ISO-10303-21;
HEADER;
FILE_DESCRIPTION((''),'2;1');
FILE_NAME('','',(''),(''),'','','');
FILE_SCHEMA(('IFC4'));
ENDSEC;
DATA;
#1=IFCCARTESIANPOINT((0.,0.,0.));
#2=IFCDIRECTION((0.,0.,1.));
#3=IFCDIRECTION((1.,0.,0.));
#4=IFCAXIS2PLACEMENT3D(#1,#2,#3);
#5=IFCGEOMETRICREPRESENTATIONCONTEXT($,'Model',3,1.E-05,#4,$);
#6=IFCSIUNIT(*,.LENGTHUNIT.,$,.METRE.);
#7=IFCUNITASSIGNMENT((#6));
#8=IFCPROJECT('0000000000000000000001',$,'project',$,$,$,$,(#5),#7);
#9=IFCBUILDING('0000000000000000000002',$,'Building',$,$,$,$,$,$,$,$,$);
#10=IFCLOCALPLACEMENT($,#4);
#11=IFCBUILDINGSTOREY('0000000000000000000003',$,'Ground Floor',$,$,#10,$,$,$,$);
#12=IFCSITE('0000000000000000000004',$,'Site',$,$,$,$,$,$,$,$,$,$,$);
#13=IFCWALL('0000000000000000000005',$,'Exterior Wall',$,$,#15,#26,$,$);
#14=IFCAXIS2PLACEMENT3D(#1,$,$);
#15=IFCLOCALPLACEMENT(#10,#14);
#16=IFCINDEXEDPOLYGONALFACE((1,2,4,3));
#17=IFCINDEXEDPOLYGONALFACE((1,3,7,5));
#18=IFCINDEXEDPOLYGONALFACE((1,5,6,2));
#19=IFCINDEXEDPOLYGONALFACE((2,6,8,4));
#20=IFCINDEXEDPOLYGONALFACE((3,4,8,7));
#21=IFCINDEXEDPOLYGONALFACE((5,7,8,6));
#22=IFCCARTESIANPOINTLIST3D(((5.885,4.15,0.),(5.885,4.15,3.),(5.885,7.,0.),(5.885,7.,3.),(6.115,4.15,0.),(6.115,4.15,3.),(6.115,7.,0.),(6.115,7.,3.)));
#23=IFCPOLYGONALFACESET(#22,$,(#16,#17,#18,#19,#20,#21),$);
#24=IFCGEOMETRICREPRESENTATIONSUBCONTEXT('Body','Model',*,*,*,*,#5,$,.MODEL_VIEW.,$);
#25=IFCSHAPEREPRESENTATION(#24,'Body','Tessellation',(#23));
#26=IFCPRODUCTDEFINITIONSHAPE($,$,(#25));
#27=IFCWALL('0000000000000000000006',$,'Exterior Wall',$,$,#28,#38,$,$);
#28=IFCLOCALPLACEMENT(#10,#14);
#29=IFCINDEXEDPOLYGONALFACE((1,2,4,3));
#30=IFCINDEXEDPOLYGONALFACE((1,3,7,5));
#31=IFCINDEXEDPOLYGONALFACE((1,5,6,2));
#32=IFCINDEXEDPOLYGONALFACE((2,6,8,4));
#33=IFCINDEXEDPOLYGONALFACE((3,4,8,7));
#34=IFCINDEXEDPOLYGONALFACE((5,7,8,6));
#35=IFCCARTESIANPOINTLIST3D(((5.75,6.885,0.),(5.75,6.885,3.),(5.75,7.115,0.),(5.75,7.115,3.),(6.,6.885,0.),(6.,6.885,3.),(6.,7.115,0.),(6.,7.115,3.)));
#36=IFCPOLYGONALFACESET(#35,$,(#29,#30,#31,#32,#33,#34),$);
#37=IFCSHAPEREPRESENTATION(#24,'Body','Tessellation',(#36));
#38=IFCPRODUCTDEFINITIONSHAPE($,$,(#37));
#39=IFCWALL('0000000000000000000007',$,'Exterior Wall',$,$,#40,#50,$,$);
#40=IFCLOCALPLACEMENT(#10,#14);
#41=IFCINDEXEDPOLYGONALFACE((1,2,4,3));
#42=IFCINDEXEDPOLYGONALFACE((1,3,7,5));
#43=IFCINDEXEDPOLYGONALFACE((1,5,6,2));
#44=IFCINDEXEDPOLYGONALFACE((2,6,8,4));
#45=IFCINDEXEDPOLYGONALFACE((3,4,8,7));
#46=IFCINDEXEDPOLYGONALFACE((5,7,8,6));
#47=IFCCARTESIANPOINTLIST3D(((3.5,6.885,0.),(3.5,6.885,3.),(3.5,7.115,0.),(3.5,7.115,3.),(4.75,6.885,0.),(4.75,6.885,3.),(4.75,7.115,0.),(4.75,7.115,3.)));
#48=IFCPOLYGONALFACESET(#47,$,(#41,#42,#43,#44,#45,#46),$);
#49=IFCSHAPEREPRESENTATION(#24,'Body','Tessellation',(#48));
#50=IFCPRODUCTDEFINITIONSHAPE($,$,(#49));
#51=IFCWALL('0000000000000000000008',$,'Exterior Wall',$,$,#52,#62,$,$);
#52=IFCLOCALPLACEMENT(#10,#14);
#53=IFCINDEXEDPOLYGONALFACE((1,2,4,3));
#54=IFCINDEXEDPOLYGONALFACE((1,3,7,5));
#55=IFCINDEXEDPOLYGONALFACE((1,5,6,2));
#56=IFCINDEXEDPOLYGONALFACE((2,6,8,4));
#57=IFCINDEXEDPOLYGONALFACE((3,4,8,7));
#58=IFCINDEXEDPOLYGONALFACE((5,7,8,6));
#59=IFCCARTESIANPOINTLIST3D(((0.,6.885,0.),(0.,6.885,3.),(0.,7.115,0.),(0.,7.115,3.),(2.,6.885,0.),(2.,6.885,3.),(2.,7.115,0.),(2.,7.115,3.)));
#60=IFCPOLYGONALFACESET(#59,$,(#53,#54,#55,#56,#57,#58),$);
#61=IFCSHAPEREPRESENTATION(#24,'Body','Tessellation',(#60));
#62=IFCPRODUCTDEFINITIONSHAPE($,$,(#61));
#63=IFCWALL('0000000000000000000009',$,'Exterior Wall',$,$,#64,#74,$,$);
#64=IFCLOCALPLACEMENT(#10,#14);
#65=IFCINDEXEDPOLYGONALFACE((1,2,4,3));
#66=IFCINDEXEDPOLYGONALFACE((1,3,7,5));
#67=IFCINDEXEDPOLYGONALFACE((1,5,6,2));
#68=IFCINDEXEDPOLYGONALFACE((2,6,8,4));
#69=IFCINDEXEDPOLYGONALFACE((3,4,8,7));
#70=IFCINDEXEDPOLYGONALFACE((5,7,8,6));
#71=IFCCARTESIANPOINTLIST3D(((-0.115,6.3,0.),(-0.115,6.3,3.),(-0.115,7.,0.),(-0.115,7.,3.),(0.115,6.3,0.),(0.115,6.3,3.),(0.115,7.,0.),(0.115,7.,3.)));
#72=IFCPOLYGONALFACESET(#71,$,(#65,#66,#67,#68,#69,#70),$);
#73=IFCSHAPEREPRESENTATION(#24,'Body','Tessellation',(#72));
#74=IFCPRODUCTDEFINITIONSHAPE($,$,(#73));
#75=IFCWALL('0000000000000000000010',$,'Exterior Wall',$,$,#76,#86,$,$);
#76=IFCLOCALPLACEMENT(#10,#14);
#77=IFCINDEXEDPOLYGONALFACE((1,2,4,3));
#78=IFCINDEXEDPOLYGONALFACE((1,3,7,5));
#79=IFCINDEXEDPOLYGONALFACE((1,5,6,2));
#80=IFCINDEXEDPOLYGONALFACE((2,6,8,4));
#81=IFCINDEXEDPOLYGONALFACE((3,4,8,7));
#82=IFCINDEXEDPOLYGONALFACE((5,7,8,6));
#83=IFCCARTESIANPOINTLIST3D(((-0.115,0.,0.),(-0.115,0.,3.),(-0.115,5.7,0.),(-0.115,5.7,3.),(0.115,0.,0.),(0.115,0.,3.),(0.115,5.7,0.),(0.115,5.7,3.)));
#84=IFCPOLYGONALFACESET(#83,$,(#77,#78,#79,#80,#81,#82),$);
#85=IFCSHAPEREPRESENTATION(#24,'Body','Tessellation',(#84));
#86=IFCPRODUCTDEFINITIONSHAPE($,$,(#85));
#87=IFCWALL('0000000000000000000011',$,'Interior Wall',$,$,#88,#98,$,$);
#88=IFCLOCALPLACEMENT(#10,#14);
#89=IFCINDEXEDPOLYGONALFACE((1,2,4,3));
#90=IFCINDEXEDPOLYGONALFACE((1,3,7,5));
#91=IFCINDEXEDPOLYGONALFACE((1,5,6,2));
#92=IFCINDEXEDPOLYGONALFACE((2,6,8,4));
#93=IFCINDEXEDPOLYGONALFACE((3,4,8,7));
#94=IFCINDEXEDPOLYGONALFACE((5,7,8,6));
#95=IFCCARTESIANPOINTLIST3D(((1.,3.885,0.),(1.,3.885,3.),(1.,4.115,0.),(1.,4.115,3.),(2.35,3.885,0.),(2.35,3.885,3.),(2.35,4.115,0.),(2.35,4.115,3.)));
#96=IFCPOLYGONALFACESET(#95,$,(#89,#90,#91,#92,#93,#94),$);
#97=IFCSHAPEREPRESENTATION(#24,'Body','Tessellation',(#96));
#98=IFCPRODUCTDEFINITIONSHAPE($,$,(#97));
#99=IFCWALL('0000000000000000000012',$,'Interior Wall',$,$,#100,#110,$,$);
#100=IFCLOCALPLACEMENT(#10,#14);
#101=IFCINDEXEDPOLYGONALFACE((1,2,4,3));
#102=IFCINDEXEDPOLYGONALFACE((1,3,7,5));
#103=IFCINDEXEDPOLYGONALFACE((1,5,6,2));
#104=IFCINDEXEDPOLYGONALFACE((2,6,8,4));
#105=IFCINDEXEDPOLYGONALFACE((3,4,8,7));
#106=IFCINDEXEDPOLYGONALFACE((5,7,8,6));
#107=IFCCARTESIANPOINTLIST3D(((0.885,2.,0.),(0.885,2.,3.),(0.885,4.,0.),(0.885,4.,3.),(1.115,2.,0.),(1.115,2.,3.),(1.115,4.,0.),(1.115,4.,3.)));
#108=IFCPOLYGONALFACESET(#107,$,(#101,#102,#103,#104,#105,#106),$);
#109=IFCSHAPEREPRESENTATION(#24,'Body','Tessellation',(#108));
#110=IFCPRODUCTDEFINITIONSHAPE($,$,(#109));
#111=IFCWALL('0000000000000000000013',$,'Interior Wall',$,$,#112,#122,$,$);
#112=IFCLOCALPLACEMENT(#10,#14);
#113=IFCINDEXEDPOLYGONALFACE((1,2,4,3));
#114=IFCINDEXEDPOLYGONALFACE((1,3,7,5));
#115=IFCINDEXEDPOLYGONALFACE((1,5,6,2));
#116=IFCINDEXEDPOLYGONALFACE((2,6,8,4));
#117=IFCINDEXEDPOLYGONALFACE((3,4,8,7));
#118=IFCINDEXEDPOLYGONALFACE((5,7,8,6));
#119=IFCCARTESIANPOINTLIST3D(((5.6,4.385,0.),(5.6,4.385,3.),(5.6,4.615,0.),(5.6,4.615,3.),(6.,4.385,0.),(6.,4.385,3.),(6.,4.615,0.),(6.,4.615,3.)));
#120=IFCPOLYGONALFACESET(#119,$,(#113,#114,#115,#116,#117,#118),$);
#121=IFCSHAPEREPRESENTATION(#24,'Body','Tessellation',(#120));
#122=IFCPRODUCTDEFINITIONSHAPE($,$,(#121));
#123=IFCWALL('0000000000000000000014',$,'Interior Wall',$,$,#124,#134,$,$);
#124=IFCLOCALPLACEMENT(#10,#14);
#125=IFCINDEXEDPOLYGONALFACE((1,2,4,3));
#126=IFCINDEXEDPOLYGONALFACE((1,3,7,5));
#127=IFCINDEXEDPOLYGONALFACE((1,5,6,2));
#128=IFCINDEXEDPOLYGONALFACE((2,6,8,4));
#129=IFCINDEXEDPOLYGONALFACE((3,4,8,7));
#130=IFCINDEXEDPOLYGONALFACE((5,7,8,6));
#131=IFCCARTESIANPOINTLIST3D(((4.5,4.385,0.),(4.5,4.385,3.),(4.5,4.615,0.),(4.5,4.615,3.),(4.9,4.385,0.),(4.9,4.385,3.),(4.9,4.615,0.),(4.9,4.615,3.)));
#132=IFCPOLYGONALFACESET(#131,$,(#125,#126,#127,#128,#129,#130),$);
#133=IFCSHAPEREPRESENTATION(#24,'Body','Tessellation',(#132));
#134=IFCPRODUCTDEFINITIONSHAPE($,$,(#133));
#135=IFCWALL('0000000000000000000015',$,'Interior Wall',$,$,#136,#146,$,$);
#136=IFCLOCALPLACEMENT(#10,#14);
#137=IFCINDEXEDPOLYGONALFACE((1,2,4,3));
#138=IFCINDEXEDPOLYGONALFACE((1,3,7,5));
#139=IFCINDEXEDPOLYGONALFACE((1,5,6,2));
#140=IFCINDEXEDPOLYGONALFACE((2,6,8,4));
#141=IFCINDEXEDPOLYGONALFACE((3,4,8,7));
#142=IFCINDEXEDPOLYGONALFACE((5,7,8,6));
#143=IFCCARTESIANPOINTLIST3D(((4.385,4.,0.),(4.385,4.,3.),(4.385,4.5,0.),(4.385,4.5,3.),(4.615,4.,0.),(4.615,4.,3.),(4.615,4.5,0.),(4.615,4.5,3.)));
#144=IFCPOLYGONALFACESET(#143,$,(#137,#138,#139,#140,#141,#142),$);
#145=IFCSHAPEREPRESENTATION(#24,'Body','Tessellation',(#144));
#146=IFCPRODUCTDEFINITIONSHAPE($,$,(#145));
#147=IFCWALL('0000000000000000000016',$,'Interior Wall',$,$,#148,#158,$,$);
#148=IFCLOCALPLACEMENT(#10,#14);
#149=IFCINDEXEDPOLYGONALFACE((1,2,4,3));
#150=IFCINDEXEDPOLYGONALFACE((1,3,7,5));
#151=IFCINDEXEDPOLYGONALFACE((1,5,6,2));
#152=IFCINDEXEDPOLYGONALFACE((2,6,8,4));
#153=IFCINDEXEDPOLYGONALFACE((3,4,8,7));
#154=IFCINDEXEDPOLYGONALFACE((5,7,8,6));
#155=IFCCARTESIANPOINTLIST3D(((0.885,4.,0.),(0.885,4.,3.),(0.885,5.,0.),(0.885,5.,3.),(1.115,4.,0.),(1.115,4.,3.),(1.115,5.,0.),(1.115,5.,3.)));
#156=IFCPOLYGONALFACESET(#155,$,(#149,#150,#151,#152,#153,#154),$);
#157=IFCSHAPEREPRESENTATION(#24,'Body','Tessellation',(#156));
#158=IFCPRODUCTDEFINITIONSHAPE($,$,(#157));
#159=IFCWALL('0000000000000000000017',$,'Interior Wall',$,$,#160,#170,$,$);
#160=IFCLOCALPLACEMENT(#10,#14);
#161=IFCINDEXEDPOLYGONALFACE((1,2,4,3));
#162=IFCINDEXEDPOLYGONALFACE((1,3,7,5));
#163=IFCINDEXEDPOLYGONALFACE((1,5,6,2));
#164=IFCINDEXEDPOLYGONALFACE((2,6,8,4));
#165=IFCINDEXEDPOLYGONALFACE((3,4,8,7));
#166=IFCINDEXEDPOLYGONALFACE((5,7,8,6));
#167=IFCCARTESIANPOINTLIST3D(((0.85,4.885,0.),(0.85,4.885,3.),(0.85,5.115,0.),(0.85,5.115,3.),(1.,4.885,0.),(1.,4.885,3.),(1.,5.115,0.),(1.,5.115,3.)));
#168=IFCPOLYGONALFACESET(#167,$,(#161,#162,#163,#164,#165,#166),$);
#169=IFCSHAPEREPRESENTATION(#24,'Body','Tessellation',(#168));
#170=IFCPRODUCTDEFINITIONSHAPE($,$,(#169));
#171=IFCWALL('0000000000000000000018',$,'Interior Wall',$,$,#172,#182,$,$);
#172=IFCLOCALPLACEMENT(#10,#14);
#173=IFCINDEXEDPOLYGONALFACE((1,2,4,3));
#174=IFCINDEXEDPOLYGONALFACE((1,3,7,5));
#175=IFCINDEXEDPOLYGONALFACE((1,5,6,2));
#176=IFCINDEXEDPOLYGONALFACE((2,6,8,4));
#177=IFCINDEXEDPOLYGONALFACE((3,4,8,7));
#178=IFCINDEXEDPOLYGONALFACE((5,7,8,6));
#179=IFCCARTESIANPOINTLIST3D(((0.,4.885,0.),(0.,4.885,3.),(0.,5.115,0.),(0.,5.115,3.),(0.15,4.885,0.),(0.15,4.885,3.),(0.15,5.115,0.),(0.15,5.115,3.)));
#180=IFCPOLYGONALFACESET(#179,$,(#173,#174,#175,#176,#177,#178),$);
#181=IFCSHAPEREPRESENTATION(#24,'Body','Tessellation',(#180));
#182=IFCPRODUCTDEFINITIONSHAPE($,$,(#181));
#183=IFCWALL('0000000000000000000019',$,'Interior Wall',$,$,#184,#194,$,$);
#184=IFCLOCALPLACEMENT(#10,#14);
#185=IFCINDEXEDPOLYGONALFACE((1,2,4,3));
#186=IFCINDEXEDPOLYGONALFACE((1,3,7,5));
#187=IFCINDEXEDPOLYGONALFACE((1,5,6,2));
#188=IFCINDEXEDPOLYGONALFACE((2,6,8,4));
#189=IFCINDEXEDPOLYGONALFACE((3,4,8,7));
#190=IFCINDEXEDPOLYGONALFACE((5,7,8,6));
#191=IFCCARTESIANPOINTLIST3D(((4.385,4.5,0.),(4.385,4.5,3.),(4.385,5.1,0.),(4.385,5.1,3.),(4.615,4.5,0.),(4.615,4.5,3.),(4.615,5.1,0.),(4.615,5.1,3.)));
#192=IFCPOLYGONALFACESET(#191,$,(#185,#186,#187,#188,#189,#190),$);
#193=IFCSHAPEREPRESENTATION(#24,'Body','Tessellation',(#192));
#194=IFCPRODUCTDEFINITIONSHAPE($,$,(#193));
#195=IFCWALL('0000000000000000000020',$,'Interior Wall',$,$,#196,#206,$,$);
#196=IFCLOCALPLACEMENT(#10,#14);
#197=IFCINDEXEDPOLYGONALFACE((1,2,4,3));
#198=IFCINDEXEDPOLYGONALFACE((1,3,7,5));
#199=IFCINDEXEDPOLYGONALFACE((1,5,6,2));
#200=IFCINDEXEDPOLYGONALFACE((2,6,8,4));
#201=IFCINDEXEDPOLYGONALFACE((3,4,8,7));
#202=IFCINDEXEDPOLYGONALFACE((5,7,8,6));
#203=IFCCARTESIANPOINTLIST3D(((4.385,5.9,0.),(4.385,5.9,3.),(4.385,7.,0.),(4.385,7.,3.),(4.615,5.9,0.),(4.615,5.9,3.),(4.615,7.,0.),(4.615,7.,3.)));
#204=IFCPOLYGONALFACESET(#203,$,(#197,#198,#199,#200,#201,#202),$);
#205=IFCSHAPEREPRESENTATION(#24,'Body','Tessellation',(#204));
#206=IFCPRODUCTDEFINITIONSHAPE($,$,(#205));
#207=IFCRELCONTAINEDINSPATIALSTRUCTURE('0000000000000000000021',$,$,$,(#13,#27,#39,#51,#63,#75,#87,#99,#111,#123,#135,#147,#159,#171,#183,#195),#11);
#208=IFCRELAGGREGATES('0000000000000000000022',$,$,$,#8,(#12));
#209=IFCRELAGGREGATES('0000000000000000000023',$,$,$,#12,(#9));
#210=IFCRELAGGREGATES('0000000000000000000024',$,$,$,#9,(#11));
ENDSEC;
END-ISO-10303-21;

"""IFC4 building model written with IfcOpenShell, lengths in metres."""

from ifc_helpers import new_model, si_unit, frame, origin_with_axes, place, context, subcontext, project, spatial, indexed_curve, outline, extrude, element, save


model = new_model("IFC4")

# Units and contexts
model_context = context("Model", 3, precision=1e-05, world=origin_with_axes())
body_context = subcontext(model_context, "Body", "Model", "MODEL_VIEW")
ifc_project = project(units=[si_unit("LENGTHUNIT", "METRE")], contexts=[model_context])

# Site, building, storey
site = spatial("IfcSite", under=ifc_project, Name="Site")
building = spatial("IfcBuilding", under=site, Name="Building")
storey_placement = place(None, origin_with_axes())
storey = spatial("IfcBuildingStorey", under=building, at=storey_placement, Name="Ground Floor")

# Walls
wall_1_placement = place(storey_placement, frame((6.0, 4.15, 0.0), z_axis=(0.0, 0.0, 1.0), x_axis=(0.0, 1.0, 0.0)))
element("IfcWall", 1, at=wall_1_placement, inside=storey, Name="Exterior Wall", context=body_context, shape_type="SweptSolid", body=[
    extrude(outline(indexed_curve([(0.0, 0.0), (0.0, 0.23), (2.85, 0.23), (2.85, 0.0), (0.0, 0.0)], self_intersect=False)), frame((0.0, -0.115, 0.0), z_axis=(0.0, 0.0, 1.0), x_axis=(1.0, 0.0, 0.0)), (0.0, 0.0, 1.0), 3.0),
])
wall_2_placement = place(storey_placement, frame((6.0, 7.0, 0.0), z_axis=(0.0, 0.0, 1.0), x_axis=(-1.0, 0.0, 0.0)))
element("IfcWall", 2, at=wall_2_placement, inside=storey, Name="Exterior Wall", context=body_context, shape_type="SweptSolid", body=[
    extrude(outline(indexed_curve([(0.0, 0.0), (0.0, 0.23), (0.25, 0.23), (0.25, 0.0), (0.0, 0.0)], self_intersect=False)), frame((0.0, -0.115, 0.0), z_axis=(0.0, 0.0, 1.0), x_axis=(1.0, 0.0, 0.0)), (0.0, 0.0, 1.0), 3.0),
])
wall_3_placement = place(storey_placement, frame((4.75, 7.0, 0.0), z_axis=(0.0, 0.0, 1.0), x_axis=(-1.0, 0.0, 0.0)))
element("IfcWall", 3, at=wall_3_placement, inside=storey, Name="Exterior Wall", context=body_context, shape_type="SweptSolid", body=[
    extrude(outline(indexed_curve([(0.0, 0.0), (0.0, 0.23), (1.25, 0.23), (1.25, 0.0), (0.0, 0.0)], self_intersect=False)), frame((0.0, -0.115, 0.0), z_axis=(0.0, 0.0, 1.0), x_axis=(1.0, 0.0, 0.0)), (0.0, 0.0, 1.0), 3.0),
])
wall_4_placement = place(storey_placement, frame((2.0, 7.0, 0.0), z_axis=(0.0, 0.0, 1.0), x_axis=(-1.0, 0.0, 0.0)))
element("IfcWall", 4, at=wall_4_placement, inside=storey, Name="Exterior Wall", context=body_context, shape_type="SweptSolid", body=[
    extrude(outline(indexed_curve([(0.0, 0.0), (0.0, 0.23), (2.0, 0.23), (2.0, 0.0), (0.0, 0.0)], self_intersect=False)), frame((0.0, -0.115, 0.0), z_axis=(0.0, 0.0, 1.0), x_axis=(1.0, 0.0, 0.0)), (0.0, 0.0, 1.0), 3.0),
])
wall_5_placement = place(storey_placement, frame((0.0, 7.0, 0.0), z_axis=(0.0, 0.0, 1.0), x_axis=(0.0, -1.0, 0.0)))
element("IfcWall", 5, at=wall_5_placement, inside=storey, Name="Exterior Wall", context=body_context, shape_type="SweptSolid", body=[
    extrude(outline(indexed_curve([(0.0, 0.0), (0.0, 0.23), (0.7, 0.23), (0.7, 0.0), (0.0, 0.0)], self_intersect=False)), frame((0.0, -0.115, 0.0), z_axis=(0.0, 0.0, 1.0), x_axis=(1.0, 0.0, 0.0)), (0.0, 0.0, 1.0), 3.0),
])
wall_6_placement = place(storey_placement, frame((0.0, 5.7, 0.0), z_axis=(0.0, 0.0, 1.0), x_axis=(0.0, -1.0, 0.0)))
element("IfcWall", 6, at=wall_6_placement, inside=storey, Name="Exterior Wall", context=body_context, shape_type="SweptSolid", body=[
    extrude(outline(indexed_curve([(0.0, 0.0), (0.0, 0.23), (5.7, 0.23), (5.7, 0.0), (0.0, 0.0)], self_intersect=False)), frame((0.0, -0.115, 0.0), z_axis=(0.0, 0.0, 1.0), x_axis=(1.0, 0.0, 0.0)), (0.0, 0.0, 1.0), 3.0),
])
wall_7_placement = place(storey_placement, frame((2.35, 4.0, 0.0), z_axis=(0.0, 0.0, 1.0), x_axis=(-1.0, 0.0, 0.0)))
element("IfcWall", 7, at=wall_7_placement, inside=storey, Name="Interior Wall", context=body_context, shape_type="SweptSolid", body=[
    extrude(outline(indexed_curve([(0.0, 0.0), (0.0, 0.23), (1.35, 0.23), (1.35, 0.0), (0.0, 0.0)], self_intersect=False)), frame((0.0, -0.115, 0.0), z_axis=(0.0, 0.0, 1.0), x_axis=(1.0, 0.0, 0.0)), (0.0, 0.0, 1.0), 3.0),
])
wall_8_placement = place(storey_placement, frame((1.0, 4.0, 0.0), z_axis=(0.0, 0.0, 1.0), x_axis=(0.0, -1.0, 0.0)))
element("IfcWall", 8, at=wall_8_placement, inside=storey, Name="Interior Wall", context=body_context, shape_type="SweptSolid", body=[
    extrude(outline(indexed_curve([(0.0, 0.0), (0.0, 0.23), (2.0, 0.23), (2.0, 0.0), (0.0, 0.0)], self_intersect=False)), frame((0.0, -0.115, 0.0), z_axis=(0.0, 0.0, 1.0), x_axis=(1.0, 0.0, 0.0)), (0.0, 0.0, 1.0), 3.0),
])
for number, where, z_axis, x_axis, name in (
    (9, (6.0, 4.5, 0.0), (0.0, 0.0, 1.0), (-1.0, 0.0, 0.0), "Interior Wall"),
    (10, (4.9, 4.5, 0.0), (0.0, 0.0, 1.0), (-1.0, 0.0, 0.0), "Interior Wall"),
):
    element("IfcWall", number, at=place(storey_placement, frame(where, z_axis=z_axis, x_axis=x_axis)), inside=storey, Name=name, context=body_context, shape_type="SweptSolid", body=[
        extrude(outline(indexed_curve([(0.0, 0.0), (0.0, 0.23), (0.4, 0.23), (0.4, 0.0), (0.0, 0.0)], self_intersect=False)), frame((0.0, -0.115, 0.0), z_axis=(0.0, 0.0, 1.0), x_axis=(1.0, 0.0, 0.0)), (0.0, 0.0, 1.0), 3.0),
    ])
wall_9_placement = place(storey_placement, frame((4.5, 4.5, 0.0), z_axis=(0.0, 0.0, 1.0), x_axis=(0.0, -1.0, 0.0)))
element("IfcWall", 11, at=wall_9_placement, inside=storey, Name="Interior Wall", context=body_context, shape_type="SweptSolid", body=[
    extrude(outline(indexed_curve([(0.0, 0.0), (0.0, 0.23), (0.5, 0.23), (0.5, 0.0), (0.0, 0.0)], self_intersect=False)), frame((0.0, -0.115, 0.0), z_axis=(0.0, 0.0, 1.0), x_axis=(1.0, 0.0, 0.0)), (0.0, 0.0, 1.0), 3.0),
])
wall_10_placement = place(storey_placement, frame((1.0, 4.0, 0.0), z_axis=(0.0, 0.0, 1.0), x_axis=(0.0, 1.0, 0.0)))
element("IfcWall", 12, at=wall_10_placement, inside=storey, Name="Interior Wall", context=body_context, shape_type="SweptSolid", body=[
    extrude(outline(indexed_curve([(0.0, 0.0), (0.0, 0.23), (1.0, 0.23), (1.0, 0.0), (0.0, 0.0)], self_intersect=False)), frame((0.0, -0.115, 0.0), z_axis=(0.0, 0.0, 1.0), x_axis=(1.0, 0.0, 0.0)), (0.0, 0.0, 1.0), 3.0),
])
for number, where, z_axis, x_axis, name in (
    (13, (1.0, 5.0, 0.0), (0.0, 0.0, 1.0), (-1.0, 0.0, 0.0), "Interior Wall"),
    (14, (0.15, 5.0, 0.0), (0.0, 0.0, 1.0), (-1.0, 0.0, 0.0), "Interior Wall"),
):
    element("IfcWall", number, at=place(storey_placement, frame(where, z_axis=z_axis, x_axis=x_axis)), inside=storey, Name=name, context=body_context, shape_type="SweptSolid", body=[
        extrude(outline(indexed_curve([(0.0, 0.0), (0.0, 0.23), (0.15, 0.23), (0.15, 0.0), (0.0, 0.0)], self_intersect=False)), frame((0.0, -0.115, 0.0), z_axis=(0.0, 0.0, 1.0), x_axis=(1.0, 0.0, 0.0)), (0.0, 0.0, 1.0), 3.0),
    ])
wall_11_placement = place(storey_placement, frame((4.5, 4.5, 0.0), z_axis=(0.0, 0.0, 1.0), x_axis=(0.0, 1.0, 0.0)))
element("IfcWall", 15, at=wall_11_placement, inside=storey, Name="Interior Wall", context=body_context, shape_type="SweptSolid", body=[
    extrude(outline(indexed_curve([(0.0, 0.0), (0.0, 0.23), (0.6, 0.23), (0.6, 0.0), (0.0, 0.0)], self_intersect=False)), frame((0.0, -0.115, 0.0), z_axis=(0.0, 0.0, 1.0), x_axis=(1.0, 0.0, 0.0)), (0.0, 0.0, 1.0), 3.0),
])
wall_12_placement = place(storey_placement, frame((4.5, 5.9, 0.0), z_axis=(0.0, 0.0, 1.0), x_axis=(0.0, 1.0, 0.0)))
element("IfcWall", 16, at=wall_12_placement, inside=storey, Name="Interior Wall", context=body_context, shape_type="SweptSolid", body=[
    extrude(outline(indexed_curve([(0.0, 0.0), (0.0, 0.23), (1.1, 0.23), (1.1, 0.0), (0.0, 0.0)], self_intersect=False)), frame((0.0, -0.115, 0.0), z_axis=(0.0, 0.0, 1.0), x_axis=(1.0, 0.0, 0.0)), (0.0, 0.0, 1.0), 3.0),
])

save(model, "model.ifc")
